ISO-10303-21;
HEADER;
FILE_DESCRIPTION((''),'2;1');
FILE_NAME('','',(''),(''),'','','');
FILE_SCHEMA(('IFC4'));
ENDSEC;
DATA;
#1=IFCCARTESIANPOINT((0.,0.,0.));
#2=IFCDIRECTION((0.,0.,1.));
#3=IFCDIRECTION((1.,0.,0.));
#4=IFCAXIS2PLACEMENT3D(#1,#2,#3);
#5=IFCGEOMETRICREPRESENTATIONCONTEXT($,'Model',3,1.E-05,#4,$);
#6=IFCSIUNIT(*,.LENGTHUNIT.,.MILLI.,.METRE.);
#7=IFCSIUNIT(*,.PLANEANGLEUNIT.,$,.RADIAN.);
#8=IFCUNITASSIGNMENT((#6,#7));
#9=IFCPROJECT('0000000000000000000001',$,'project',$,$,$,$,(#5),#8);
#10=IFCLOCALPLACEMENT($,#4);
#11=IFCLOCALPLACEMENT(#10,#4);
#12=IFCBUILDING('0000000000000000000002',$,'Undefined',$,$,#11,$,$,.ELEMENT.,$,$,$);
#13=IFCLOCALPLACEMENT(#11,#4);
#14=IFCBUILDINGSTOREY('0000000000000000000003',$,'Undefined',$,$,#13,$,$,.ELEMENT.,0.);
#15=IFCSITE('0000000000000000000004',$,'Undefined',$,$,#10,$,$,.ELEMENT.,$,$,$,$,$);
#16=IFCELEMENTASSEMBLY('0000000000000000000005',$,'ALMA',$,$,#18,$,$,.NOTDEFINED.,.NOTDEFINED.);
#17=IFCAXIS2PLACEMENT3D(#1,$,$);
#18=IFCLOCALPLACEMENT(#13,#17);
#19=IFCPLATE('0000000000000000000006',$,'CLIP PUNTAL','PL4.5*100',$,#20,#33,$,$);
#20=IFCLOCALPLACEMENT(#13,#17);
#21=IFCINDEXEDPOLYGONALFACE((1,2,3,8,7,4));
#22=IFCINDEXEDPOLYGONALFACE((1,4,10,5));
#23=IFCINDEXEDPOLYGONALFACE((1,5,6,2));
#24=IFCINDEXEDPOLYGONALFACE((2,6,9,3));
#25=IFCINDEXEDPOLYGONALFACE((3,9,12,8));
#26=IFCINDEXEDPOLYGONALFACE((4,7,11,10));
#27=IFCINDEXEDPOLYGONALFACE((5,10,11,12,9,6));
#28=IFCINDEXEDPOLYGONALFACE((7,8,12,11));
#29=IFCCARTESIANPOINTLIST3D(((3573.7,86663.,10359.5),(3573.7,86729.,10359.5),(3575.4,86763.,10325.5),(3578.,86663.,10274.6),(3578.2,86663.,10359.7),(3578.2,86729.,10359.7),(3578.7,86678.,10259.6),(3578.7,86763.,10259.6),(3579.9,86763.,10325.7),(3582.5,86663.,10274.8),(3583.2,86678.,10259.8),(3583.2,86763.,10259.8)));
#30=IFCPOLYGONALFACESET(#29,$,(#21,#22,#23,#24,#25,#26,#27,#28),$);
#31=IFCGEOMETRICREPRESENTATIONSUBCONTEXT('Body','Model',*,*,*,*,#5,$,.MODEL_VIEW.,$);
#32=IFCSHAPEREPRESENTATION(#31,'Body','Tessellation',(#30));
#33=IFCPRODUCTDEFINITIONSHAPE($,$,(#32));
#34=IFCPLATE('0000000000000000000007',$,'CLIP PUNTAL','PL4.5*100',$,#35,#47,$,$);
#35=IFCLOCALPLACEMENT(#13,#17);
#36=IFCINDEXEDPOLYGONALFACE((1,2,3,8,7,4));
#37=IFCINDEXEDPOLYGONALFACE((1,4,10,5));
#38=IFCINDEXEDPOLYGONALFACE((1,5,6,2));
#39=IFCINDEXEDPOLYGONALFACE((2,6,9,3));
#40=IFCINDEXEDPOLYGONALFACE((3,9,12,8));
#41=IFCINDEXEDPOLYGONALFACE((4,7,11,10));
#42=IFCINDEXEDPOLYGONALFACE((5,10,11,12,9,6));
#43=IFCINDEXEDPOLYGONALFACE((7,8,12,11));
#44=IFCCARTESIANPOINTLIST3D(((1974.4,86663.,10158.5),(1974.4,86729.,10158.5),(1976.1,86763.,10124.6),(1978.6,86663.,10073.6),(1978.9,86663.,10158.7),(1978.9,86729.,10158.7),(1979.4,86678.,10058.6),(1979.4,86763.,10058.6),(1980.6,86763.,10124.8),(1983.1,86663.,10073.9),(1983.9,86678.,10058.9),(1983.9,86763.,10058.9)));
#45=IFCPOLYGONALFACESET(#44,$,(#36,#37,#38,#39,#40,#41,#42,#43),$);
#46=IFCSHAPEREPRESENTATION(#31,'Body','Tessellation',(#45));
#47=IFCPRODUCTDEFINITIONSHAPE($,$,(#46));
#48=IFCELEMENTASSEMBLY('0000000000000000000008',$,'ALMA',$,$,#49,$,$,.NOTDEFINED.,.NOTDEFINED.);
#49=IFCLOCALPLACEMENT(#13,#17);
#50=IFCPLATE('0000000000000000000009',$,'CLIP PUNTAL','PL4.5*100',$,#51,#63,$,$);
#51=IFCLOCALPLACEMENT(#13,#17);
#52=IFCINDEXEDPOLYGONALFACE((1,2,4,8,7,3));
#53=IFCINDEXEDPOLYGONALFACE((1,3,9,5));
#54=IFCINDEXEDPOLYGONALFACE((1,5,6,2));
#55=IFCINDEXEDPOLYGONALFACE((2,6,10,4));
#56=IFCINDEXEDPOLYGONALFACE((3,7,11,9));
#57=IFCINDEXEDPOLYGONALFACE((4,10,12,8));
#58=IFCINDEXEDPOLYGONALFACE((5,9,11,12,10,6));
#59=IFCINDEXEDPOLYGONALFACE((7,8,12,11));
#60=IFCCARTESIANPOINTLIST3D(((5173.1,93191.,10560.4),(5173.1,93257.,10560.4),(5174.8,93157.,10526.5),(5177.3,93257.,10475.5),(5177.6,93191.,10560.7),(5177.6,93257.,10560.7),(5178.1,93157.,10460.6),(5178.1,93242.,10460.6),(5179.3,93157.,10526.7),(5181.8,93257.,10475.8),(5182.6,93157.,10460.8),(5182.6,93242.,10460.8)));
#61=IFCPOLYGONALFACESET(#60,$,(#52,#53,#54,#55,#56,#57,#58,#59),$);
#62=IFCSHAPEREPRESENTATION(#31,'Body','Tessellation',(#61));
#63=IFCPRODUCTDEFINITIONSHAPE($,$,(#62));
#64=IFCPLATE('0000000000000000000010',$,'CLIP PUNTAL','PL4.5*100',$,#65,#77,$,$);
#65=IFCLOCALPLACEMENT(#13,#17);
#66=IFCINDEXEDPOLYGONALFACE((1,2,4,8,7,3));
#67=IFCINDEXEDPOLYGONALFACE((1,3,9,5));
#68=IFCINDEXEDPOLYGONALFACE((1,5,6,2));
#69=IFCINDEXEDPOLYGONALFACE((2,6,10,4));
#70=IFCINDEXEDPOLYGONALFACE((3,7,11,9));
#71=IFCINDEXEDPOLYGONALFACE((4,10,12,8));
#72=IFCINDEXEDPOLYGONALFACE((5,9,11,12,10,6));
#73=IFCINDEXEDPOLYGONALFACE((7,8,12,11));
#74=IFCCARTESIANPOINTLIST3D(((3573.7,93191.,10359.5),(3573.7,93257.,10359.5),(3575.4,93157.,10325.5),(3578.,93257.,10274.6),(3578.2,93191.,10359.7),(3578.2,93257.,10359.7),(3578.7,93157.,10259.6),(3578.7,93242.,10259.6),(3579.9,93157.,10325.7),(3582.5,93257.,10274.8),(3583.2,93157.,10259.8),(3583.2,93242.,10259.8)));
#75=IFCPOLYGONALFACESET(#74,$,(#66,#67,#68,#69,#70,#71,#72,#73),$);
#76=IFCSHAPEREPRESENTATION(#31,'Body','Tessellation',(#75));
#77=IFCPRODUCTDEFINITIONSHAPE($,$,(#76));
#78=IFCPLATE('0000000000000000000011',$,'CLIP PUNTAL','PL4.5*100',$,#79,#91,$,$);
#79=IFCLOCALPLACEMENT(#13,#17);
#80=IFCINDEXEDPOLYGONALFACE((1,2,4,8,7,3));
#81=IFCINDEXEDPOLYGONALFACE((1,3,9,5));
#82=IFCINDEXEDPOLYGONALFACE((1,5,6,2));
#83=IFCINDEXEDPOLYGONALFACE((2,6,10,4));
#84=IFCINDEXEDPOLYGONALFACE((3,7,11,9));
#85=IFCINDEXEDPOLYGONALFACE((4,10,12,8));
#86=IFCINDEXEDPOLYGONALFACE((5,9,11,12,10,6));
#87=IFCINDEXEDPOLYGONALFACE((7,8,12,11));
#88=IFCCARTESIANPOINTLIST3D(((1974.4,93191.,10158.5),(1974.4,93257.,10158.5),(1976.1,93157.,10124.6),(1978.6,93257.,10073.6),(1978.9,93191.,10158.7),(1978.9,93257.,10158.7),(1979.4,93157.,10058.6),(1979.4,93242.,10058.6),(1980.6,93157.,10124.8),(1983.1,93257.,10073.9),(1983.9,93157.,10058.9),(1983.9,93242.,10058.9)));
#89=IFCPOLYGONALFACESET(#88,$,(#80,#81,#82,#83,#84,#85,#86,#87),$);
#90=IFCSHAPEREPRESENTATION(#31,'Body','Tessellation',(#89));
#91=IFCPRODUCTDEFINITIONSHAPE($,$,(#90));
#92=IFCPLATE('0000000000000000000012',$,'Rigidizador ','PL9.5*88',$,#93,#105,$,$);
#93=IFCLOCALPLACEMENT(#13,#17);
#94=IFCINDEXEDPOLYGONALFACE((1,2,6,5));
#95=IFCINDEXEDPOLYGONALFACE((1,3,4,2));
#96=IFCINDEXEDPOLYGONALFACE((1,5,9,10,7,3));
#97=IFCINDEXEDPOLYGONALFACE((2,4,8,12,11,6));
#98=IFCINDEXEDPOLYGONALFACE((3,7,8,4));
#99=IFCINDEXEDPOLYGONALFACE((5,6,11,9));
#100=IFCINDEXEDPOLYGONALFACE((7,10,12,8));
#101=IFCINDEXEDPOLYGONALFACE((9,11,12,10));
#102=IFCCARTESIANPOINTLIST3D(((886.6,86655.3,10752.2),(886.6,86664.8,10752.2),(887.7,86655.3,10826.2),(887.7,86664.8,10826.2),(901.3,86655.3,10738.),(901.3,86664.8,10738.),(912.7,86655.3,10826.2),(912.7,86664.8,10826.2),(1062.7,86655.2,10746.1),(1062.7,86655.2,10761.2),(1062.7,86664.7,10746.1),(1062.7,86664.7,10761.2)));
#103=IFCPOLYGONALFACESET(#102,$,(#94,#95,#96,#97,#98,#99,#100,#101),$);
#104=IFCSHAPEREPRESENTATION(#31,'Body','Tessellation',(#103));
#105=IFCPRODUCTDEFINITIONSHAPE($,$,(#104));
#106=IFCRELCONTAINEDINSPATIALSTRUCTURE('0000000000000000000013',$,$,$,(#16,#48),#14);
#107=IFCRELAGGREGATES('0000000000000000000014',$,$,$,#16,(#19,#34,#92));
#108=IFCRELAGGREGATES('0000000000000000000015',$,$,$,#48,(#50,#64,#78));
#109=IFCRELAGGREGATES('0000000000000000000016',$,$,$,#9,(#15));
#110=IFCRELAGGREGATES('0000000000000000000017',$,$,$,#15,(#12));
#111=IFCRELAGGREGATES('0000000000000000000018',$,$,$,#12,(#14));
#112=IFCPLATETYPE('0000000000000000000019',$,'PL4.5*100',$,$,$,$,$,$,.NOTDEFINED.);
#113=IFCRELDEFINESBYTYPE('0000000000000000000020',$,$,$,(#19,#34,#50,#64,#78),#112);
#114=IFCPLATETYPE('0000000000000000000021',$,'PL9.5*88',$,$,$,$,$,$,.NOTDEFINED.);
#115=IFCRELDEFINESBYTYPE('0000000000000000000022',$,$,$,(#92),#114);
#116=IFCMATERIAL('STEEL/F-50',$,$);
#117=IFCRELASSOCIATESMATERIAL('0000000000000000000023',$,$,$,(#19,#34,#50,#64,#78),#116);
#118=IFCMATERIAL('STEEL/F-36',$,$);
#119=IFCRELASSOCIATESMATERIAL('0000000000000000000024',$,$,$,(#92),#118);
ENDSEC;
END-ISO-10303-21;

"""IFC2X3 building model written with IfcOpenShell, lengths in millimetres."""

from ifc_helpers import new_model, si_unit, frame, origin_with_axes, place, context, subcontext, project, spatial, polyline, outline, extrude, material, type_object, element, aggregate, save


model = new_model("IFC2X3")

# Units and contexts
model_context = context("Model", 3, precision=1e-05, world=origin_with_axes())
body_context = subcontext(model_context, "Body", "Model", "MODEL_VIEW")
ifc_project = project(units=[si_unit("LENGTHUNIT", "METRE", prefix="MILLI"), si_unit("PLANEANGLEUNIT", "RADIAN")], contexts=[model_context])

# Site, building, storey
site_placement = place(None, origin_with_axes())
site = spatial("IfcSite", under=ifc_project, at=site_placement, Name="Undefined", CompositionType="ELEMENT")
building_placement = place(site_placement, origin_with_axes())
building = spatial("IfcBuilding", under=site, at=building_placement, Name="Undefined", CompositionType="ELEMENT")
storey_placement = place(building_placement, origin_with_axes())
storey = spatial("IfcBuildingStorey", under=building, at=storey_placement, Name="Undefined", CompositionType="ELEMENT", Elevation=0.0)

# Element assemblies, plates
assembly_1_placement = place(storey_placement, origin_with_axes())
assembly_1 = element("IfcElementAssembly", 1, at=assembly_1_placement, inside=storey, Name="ALMA", AssemblyPlace="NOTDEFINED", PredefinedType="NOTDEFINED")
ifc_material_1 = material(Name="STEEL/F-50")
plate_type_1 = type_object("IfcPlateType", Name="PL4.5*100", PredefinedType="NOTDEFINED")
plate_1_placement = place(assembly_1_placement, frame((3576.0, 86663.0, 10359.6), z_axis=(-0.998754, 0.0, -0.049896), x_axis=(0.0, 1.0, 0.0)))
plate_1 = element("IfcPlate", 2, at=plate_1_placement, type_object=plate_type_1, material=ifc_material_1, Name="CLIP PUNTAL", Description="PL4.5*100", context=body_context, shape_type="SweptSolid", body=[
    extrude(outline(polyline([(0.0, 0.0), (66.0, 0.0), (100.0, 34.0), (100.0, 100.0), (15.0, 100.0), (0.0, 85.0), (0.0, 0.0)])), frame((0.0, 0.0, -2.2), z_axis=(0.0, 0.0, 1.0), x_axis=(1.0, 0.0, 0.0)), (0.0, 0.0, 1.0), 4.5),
])
plate_2_placement = place(assembly_1_placement, frame((1976.6, 86663.0, 10158.6), z_axis=(-0.998754, 0.0, -0.049896), x_axis=(0.0, 1.0, 0.0)))
plate_2 = element("IfcPlate", 3, at=plate_2_placement, type_object=plate_type_1, material=ifc_material_1, Name="CLIP PUNTAL", Description="PL4.5*100", context=body_context, shape_type="SweptSolid", body=[
    extrude(outline(polyline([(0.0, 0.0), (66.0, 0.0), (100.0, 34.0), (100.0, 100.0), (15.0, 100.0), (0.0, 85.0), (0.0, 0.0)])), frame((0.0, 0.0, -2.2), z_axis=(0.0, 0.0, 1.0), x_axis=(1.0, 0.0, 0.0)), (0.0, 0.0, 1.0), 4.5),
])
assembly_2_placement = place(storey_placement, origin_with_axes())
assembly_2 = element("IfcElementAssembly", 4, at=assembly_2_placement, inside=storey, Name="ALMA", AssemblyPlace="NOTDEFINED", PredefinedType="NOTDEFINED")
plate_3_placement = place(assembly_2_placement, frame((5175.3, 93257.0, 10560.5), z_axis=(0.998754, 0.0, 0.049896), x_axis=(0.0, -1.0, 0.0)))
plate_3 = element("IfcPlate", 5, at=plate_3_placement, type_object=plate_type_1, material=ifc_material_1, Name="CLIP PUNTAL", Description="PL4.5*100", context=body_context, shape_type="SweptSolid", body=[
    extrude(outline(polyline([(0.0, 0.0), (66.0, 0.0), (100.0, 34.0), (100.0, 100.0), (15.0, 100.0), (0.0, 85.0), (0.0, 0.0)])), frame((0.0, 0.0, -2.2), z_axis=(0.0, 0.0, 1.0), x_axis=(1.0, 0.0, 0.0)), (0.0, 0.0, 1.0), 4.5),
])
plate_4_placement = place(assembly_2_placement, frame((3576.0, 93257.0, 10359.6), z_axis=(0.998754, 0.0, 0.049896), x_axis=(0.0, -1.0, 0.0)))
plate_4 = element("IfcPlate", 6, at=plate_4_placement, type_object=plate_type_1, material=ifc_material_1, Name="CLIP PUNTAL", Description="PL4.5*100", context=body_context, shape_type="SweptSolid", body=[
    extrude(outline(polyline([(0.0, 0.0), (66.0, 0.0), (100.0, 34.0), (100.0, 100.0), (15.0, 100.0), (0.0, 85.0), (0.0, 0.0)])), frame((0.0, 0.0, -2.2), z_axis=(0.0, 0.0, 1.0), x_axis=(1.0, 0.0, 0.0)), (0.0, 0.0, 1.0), 4.5),
])
plate_5_placement = place(assembly_2_placement, frame((1976.6, 93257.0, 10158.6), z_axis=(0.998754, 0.0, 0.049896), x_axis=(0.0, -1.0, 0.0)))
plate_5 = element("IfcPlate", 7, at=plate_5_placement, type_object=plate_type_1, material=ifc_material_1, Name="CLIP PUNTAL", Description="PL4.5*100", context=body_context, shape_type="SweptSolid", body=[
    extrude(outline(polyline([(0.0, 0.0), (66.0, 0.0), (100.0, 34.0), (100.0, 100.0), (15.0, 100.0), (0.0, 85.0), (0.0, 0.0)])), frame((0.0, 0.0, -2.2), z_axis=(0.0, 0.0, 1.0), x_axis=(1.0, 0.0, 0.0)), (0.0, 0.0, 1.0), 4.5),
])

# Plate
ifc_material_2 = material(Name="STEEL/F-36")
plate_type_2 = type_object("IfcPlateType", Name="PL9.5*88", PredefinedType="NOTDEFINED")
plate_6_placement = place(assembly_1_placement, frame((1062.7, 86660.0, 10826.2), z_axis=(0.0, -1.0, 0.0), x_axis=(-1.0, 0.0, 0.0)))
plate_6 = element("IfcPlate", 8, at=plate_6_placement, type_object=plate_type_2, material=ifc_material_2, Name="Rigidizador ", Description="PL9.5*88", context=body_context, shape_type="SweptSolid", body=[
    extrude(outline(polyline([(0.0, 65.0), (150.0, 0.0), (175.0, 0.0), (176.1, 74.0), (161.4, 88.2), (0.0, 80.2), (0.0, 65.0)])), frame((0.0, 0.0, -4.8), z_axis=(0.0, 0.0, 1.0), x_axis=(1.0, 0.0, 0.0)), (0.0, 0.0, 1.0), 9.5),
])

aggregate(assembly_1, [plate_1, plate_2, plate_6])
aggregate(assembly_2, [plate_3, plate_4, plate_5])

save(model, "model.ifc")
